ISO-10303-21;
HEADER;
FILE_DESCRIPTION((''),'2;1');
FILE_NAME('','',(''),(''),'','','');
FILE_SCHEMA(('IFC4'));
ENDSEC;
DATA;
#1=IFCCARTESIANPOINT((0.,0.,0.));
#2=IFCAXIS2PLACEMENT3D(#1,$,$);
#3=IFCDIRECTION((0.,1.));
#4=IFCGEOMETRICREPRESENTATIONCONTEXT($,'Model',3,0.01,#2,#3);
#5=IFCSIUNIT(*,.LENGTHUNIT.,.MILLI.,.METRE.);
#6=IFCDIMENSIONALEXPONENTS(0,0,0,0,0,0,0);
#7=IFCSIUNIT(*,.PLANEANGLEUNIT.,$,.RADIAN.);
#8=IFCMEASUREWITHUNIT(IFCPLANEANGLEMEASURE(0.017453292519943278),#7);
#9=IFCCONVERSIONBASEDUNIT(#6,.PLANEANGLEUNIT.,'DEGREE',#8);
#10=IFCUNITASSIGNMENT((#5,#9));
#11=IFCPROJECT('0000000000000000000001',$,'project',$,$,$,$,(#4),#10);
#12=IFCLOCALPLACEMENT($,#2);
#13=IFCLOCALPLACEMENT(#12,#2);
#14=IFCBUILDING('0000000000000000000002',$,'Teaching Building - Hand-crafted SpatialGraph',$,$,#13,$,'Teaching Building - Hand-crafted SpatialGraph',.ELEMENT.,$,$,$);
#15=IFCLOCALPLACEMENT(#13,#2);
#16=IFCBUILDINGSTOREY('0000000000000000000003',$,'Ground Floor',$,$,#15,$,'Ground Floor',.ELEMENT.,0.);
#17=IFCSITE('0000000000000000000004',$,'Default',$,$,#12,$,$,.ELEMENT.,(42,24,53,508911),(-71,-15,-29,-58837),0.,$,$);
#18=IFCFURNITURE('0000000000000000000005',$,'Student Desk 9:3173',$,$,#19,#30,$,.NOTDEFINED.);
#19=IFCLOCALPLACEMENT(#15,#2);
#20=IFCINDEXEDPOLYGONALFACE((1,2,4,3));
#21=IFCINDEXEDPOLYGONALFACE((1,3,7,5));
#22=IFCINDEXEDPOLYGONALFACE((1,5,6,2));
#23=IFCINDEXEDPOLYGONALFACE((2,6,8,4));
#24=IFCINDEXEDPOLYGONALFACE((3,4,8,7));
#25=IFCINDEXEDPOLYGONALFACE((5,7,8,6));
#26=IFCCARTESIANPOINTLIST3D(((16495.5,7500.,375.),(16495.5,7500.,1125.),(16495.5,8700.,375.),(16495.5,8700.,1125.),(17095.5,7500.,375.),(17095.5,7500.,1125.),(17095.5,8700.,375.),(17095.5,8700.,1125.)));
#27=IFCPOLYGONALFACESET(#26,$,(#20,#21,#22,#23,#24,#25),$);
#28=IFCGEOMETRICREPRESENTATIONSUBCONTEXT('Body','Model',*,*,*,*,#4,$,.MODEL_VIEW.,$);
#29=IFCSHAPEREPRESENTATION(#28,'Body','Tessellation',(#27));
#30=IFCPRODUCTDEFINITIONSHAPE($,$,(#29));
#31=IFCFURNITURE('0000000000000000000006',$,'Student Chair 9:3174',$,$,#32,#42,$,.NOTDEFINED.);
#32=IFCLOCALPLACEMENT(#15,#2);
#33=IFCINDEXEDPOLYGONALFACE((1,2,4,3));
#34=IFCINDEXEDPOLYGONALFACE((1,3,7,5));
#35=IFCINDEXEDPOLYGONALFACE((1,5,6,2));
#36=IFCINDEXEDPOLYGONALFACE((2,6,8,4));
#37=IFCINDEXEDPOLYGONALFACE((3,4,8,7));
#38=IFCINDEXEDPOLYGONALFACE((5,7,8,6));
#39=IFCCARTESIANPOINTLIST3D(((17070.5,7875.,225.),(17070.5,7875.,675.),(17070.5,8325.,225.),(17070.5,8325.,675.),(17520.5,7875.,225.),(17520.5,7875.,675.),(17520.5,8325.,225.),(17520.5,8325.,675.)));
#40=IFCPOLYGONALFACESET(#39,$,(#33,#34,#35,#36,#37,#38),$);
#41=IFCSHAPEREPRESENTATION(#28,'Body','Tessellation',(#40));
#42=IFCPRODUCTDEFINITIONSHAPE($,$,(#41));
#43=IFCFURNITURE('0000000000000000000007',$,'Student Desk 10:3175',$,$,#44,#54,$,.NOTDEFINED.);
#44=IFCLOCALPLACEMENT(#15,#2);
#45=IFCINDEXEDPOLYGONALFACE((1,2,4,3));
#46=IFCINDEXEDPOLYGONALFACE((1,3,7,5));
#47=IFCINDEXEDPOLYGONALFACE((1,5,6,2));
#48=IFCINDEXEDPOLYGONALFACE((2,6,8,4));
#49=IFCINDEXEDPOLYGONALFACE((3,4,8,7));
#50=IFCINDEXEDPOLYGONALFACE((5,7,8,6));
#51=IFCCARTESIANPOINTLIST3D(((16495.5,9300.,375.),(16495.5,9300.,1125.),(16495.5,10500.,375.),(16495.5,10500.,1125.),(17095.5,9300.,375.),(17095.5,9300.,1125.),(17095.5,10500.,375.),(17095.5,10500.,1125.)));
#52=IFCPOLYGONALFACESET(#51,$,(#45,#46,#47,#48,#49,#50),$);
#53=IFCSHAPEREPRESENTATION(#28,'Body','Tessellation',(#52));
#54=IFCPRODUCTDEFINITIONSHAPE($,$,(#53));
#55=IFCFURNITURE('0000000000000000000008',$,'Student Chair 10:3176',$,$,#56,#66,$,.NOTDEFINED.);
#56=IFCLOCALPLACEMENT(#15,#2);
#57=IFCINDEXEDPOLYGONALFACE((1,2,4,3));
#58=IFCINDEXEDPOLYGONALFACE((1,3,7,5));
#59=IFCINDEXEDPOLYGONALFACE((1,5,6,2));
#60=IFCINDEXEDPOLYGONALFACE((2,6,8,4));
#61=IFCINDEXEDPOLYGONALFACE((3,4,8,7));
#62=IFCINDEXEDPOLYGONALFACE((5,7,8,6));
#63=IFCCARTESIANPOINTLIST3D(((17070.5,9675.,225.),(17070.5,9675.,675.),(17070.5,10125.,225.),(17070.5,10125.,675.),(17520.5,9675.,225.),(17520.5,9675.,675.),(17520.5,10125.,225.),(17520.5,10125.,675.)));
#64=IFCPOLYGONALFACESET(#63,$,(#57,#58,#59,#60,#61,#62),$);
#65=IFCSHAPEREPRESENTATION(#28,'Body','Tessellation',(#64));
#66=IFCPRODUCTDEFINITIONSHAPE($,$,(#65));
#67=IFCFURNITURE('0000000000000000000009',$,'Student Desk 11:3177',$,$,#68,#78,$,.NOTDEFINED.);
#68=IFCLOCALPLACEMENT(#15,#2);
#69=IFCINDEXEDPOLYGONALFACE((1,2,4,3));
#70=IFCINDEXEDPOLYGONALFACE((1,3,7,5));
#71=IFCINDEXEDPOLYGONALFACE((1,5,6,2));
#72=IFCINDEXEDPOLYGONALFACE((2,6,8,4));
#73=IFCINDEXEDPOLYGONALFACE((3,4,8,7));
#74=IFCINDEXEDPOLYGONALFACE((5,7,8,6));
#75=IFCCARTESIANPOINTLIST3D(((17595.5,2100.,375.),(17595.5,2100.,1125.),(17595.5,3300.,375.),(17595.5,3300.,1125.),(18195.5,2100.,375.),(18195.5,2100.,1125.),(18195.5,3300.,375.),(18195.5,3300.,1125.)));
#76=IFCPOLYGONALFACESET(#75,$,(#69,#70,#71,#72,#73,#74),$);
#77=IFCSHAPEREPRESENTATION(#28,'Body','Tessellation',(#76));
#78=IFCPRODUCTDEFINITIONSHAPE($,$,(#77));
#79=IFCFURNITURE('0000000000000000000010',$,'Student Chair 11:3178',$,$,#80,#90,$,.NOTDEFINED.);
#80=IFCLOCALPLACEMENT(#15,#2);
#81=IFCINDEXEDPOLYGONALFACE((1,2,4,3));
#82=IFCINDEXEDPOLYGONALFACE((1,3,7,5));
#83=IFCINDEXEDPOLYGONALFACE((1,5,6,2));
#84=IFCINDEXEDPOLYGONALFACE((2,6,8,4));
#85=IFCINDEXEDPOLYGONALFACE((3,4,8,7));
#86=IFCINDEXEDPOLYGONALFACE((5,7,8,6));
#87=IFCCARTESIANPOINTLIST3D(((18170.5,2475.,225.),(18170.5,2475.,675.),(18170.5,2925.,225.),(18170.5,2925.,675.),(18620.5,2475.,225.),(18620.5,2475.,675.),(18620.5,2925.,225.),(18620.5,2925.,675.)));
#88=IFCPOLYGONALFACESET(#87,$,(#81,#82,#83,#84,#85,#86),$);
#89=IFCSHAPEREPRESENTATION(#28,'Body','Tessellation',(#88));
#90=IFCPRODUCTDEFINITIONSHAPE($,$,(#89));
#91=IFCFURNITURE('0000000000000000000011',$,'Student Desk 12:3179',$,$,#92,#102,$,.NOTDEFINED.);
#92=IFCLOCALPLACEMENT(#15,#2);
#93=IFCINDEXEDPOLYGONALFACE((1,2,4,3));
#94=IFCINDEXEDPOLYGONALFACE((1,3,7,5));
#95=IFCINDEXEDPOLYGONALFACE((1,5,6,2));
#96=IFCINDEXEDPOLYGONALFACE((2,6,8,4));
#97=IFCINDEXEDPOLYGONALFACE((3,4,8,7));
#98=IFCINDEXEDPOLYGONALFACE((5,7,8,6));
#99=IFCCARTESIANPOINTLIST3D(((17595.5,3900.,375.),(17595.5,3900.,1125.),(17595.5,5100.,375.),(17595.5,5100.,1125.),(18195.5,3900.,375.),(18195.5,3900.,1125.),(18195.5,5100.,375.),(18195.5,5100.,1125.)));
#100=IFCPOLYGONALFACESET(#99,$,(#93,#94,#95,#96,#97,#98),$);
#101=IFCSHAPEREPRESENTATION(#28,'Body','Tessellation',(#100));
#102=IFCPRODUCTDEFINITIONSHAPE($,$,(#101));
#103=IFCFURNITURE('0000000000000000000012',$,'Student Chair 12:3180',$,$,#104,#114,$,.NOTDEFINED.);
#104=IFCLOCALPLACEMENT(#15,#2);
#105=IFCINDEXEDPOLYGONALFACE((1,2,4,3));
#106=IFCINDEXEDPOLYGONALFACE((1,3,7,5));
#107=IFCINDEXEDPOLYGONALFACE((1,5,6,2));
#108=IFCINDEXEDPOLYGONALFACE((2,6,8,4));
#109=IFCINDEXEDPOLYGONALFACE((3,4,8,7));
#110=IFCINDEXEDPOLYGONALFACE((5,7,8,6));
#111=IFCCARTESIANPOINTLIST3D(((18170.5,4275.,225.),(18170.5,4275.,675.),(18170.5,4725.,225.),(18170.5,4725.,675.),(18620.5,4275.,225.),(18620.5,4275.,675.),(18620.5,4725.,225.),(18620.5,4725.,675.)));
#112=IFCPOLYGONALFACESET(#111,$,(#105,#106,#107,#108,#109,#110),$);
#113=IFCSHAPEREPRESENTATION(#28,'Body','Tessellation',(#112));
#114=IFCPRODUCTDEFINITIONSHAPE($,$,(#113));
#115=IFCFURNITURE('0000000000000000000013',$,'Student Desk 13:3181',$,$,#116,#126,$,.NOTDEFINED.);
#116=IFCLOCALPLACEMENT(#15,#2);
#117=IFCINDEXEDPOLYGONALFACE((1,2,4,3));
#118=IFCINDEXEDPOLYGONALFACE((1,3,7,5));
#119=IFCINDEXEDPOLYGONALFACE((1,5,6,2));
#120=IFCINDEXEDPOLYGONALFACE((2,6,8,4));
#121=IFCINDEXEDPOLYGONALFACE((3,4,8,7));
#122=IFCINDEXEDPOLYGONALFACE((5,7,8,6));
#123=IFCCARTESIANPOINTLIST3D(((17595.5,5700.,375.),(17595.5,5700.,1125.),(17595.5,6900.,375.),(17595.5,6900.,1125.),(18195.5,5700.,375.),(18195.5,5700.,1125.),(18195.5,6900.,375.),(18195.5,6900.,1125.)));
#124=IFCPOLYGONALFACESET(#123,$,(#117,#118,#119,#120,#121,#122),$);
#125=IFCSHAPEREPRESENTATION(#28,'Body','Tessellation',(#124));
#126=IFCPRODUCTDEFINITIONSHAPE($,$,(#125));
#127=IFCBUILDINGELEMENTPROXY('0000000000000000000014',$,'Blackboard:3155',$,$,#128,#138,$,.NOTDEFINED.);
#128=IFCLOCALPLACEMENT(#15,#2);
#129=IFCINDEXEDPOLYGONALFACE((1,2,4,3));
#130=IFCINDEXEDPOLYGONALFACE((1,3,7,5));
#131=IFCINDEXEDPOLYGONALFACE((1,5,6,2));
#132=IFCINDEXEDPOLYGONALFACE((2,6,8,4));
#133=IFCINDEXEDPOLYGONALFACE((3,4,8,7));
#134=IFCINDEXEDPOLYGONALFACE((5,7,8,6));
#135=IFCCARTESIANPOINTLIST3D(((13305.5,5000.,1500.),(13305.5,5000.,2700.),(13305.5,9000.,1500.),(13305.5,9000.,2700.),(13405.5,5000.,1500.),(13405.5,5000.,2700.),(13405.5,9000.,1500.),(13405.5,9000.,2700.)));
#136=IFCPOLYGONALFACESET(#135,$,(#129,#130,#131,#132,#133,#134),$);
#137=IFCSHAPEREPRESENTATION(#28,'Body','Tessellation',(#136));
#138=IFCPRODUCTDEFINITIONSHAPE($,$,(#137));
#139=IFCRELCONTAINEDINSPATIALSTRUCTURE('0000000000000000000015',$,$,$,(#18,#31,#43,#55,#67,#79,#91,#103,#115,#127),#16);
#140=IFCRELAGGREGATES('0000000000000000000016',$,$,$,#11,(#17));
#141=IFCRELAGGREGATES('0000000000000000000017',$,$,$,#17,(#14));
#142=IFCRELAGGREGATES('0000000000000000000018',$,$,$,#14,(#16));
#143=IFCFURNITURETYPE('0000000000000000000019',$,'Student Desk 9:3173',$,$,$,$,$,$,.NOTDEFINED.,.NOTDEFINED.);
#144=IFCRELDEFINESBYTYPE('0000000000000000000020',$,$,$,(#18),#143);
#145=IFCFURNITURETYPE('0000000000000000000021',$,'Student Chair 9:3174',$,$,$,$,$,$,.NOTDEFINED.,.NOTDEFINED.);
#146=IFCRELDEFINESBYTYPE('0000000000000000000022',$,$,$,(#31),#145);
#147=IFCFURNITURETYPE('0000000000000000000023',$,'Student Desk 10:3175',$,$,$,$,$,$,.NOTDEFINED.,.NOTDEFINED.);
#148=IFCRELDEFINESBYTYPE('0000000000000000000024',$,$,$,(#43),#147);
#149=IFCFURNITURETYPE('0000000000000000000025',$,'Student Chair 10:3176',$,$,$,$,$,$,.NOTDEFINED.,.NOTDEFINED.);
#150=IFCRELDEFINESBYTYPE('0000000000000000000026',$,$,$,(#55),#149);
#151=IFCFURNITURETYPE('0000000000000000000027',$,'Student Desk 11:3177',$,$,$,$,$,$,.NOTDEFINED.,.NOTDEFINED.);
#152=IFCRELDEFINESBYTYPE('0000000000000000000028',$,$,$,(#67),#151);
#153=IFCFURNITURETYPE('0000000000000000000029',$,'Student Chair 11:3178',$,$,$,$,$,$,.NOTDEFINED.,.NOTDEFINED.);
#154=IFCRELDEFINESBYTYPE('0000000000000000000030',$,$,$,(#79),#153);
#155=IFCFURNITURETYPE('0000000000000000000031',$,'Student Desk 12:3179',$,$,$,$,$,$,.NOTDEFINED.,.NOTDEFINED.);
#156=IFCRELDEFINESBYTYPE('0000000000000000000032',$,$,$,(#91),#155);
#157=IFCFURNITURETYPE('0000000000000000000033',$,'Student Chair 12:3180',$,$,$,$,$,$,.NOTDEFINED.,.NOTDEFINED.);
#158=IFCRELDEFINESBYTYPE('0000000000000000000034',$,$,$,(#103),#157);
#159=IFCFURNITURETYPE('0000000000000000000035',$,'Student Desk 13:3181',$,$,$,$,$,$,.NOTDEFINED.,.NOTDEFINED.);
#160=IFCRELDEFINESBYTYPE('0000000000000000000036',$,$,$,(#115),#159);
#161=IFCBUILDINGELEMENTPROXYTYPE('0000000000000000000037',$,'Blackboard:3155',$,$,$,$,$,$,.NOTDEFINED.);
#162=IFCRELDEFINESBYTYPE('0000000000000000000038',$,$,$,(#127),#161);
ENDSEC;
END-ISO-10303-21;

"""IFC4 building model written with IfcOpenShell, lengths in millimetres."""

from ifc_helpers import new_model, entity, si_unit, converted_unit, direction, frame, frame_2d, origin, origin_2d_with_axis, place, context, subcontext, project, spatial, rectangle, extrude, type_object, element, save


model = new_model("IFC4")

# Units and contexts
model_context = context("Model", 3, precision=0.01, world=origin(), true_north=direction((0.0, 1.0)))
body_context = subcontext(model_context, "Body", "Model", "MODEL_VIEW")
ifc_project = project(units=[si_unit("LENGTHUNIT", "METRE", prefix="MILLI"), converted_unit("PLANEANGLEUNIT", "DEGREE", entity("IfcPlaneAngleMeasure", 0.017453292519943278), si_unit("PLANEANGLEUNIT", "RADIAN"), dimensions=[0, 0, 0, 0, 0, 0, 0])], contexts=[model_context])

# Site, building, storey
site_placement = place(None, origin())
site = spatial("IfcSite", under=ifc_project, at=site_placement, Name="Default", CompositionType="ELEMENT", RefLatitude=(42, 24, 53, 508911), RefLongitude=(-71, -15, -29, -58837), RefElevation=0.0)
building_placement = place(site_placement, origin())
building = spatial("IfcBuilding", under=site, at=building_placement, Name="Teaching Building - Hand-crafted SpatialGraph", LongName="Teaching Building - Hand-crafted SpatialGraph", CompositionType="ELEMENT")
storey_placement = place(building_placement, origin())
storey = spatial("IfcBuildingStorey", under=building, at=storey_placement, Name="Ground Floor", LongName="Ground Floor", CompositionType="ELEMENT", Elevation=0.0)

# Furniture
furniture_type_1 = type_object("IfcFurnitureType", Name="Student Desk 9:3173", PredefinedType="NOTDEFINED")
furniture_1_placement = place(storey_placement, origin())
element("IfcFurniture", 1, at=furniture_1_placement, inside=storey, type_object=furniture_type_1, Name="Student Desk 9:3173", PredefinedType="NOTDEFINED", context=body_context, shape_type="SweptSolid", body=[
    extrude(rectangle(XDim=1200.0, YDim=600.0, at=origin_2d_with_axis()), frame((16795.5, 8100.0, 375.0), z_axis=(0.0, 0.0, 1.0), x_axis=(0.0, 1.0, 0.0)), (0.0, 0.0, 1.0), 750.0),
])
furniture_type_2 = type_object("IfcFurnitureType", Name="Student Chair 9:3174", PredefinedType="NOTDEFINED")
furniture_2_placement = place(storey_placement, origin())
element("IfcFurniture", 2, at=furniture_2_placement, inside=storey, type_object=furniture_type_2, Name="Student Chair 9:3174", PredefinedType="NOTDEFINED", context=body_context, shape_type="SweptSolid", body=[
    extrude(rectangle(XDim=450.0, YDim=450.0, at=origin_2d_with_axis()), frame((17295.5, 8100.0, 225.0)), (0.0, 0.0, 1.0), 450.0),
])
furniture_type_3 = type_object("IfcFurnitureType", Name="Student Desk 10:3175", PredefinedType="NOTDEFINED")
furniture_3_placement = place(storey_placement, origin())
element("IfcFurniture", 3, at=furniture_3_placement, inside=storey, type_object=furniture_type_3, Name="Student Desk 10:3175", PredefinedType="NOTDEFINED", context=body_context, shape_type="SweptSolid", body=[
    extrude(rectangle(XDim=1200.0, YDim=600.0, at=origin_2d_with_axis()), frame((16795.5, 9900.0, 375.0), z_axis=(0.0, 0.0, 1.0), x_axis=(0.0, 1.0, 0.0)), (0.0, 0.0, 1.0), 750.0),
])
furniture_type_4 = type_object("IfcFurnitureType", Name="Student Chair 10:3176", PredefinedType="NOTDEFINED")
furniture_4_placement = place(storey_placement, origin())
element("IfcFurniture", 4, at=furniture_4_placement, inside=storey, type_object=furniture_type_4, Name="Student Chair 10:3176", PredefinedType="NOTDEFINED", context=body_context, shape_type="SweptSolid", body=[
    extrude(rectangle(XDim=450.0, YDim=450.0, at=frame_2d((0.0, 0.0), x_axis=(1.0, 0.0))), frame((17295.5, 9900.0, 225.0)), (0.0, 0.0, 1.0), 450.0),
])
furniture_type_5 = type_object("IfcFurnitureType", Name="Student Desk 11:3177", PredefinedType="NOTDEFINED")
furniture_5_placement = place(storey_placement, origin())
element("IfcFurniture", 5, at=furniture_5_placement, inside=storey, type_object=furniture_type_5, Name="Student Desk 11:3177", PredefinedType="NOTDEFINED", context=body_context, shape_type="SweptSolid", body=[
    extrude(rectangle(XDim=1200.0, YDim=600.0, at=origin_2d_with_axis()), frame((17895.5, 2700.0, 375.0), z_axis=(0.0, 0.0, 1.0), x_axis=(0.0, 1.0, 0.0)), (0.0, 0.0, 1.0), 750.0),
])
furniture_type_6 = type_object("IfcFurnitureType", Name="Student Chair 11:3178", PredefinedType="NOTDEFINED")
furniture_6_placement = place(storey_placement, origin())
element("IfcFurniture", 6, at=furniture_6_placement, inside=storey, type_object=furniture_type_6, Name="Student Chair 11:3178", PredefinedType="NOTDEFINED", context=body_context, shape_type="SweptSolid", body=[
    extrude(rectangle(XDim=450.0, YDim=450.0, at=origin_2d_with_axis()), frame((18395.5, 2700.0, 225.0)), (0.0, 0.0, 1.0), 450.0),
])
furniture_type_7 = type_object("IfcFurnitureType", Name="Student Desk 12:3179", PredefinedType="NOTDEFINED")
furniture_7_placement = place(storey_placement, origin())
element("IfcFurniture", 7, at=furniture_7_placement, inside=storey, type_object=furniture_type_7, Name="Student Desk 12:3179", PredefinedType="NOTDEFINED", context=body_context, shape_type="SweptSolid", body=[
    extrude(rectangle(XDim=1200.0, YDim=600.0, at=frame_2d((0.0, 0.0), x_axis=(1.0, 0.0))), frame((17895.5, 4500.0, 375.0), z_axis=(0.0, 0.0, 1.0), x_axis=(0.0, 1.0, 0.0)), (0.0, 0.0, 1.0), 750.0),
])
furniture_type_8 = type_object("IfcFurnitureType", Name="Student Chair 12:3180", PredefinedType="NOTDEFINED")
furniture_8_placement = place(storey_placement, origin())
element("IfcFurniture", 8, at=furniture_8_placement, inside=storey, type_object=furniture_type_8, Name="Student Chair 12:3180", PredefinedType="NOTDEFINED", context=body_context, shape_type="SweptSolid", body=[
    extrude(rectangle(XDim=450.0, YDim=450.0, at=origin_2d_with_axis()), frame((18395.5, 4500.0, 225.0)), (0.0, 0.0, 1.0), 450.0),
])
furniture_type_9 = type_object("IfcFurnitureType", Name="Student Desk 13:3181", PredefinedType="NOTDEFINED")
furniture_9_placement = place(storey_placement, origin())
element("IfcFurniture", 9, at=furniture_9_placement, inside=storey, type_object=furniture_type_9, Name="Student Desk 13:3181", PredefinedType="NOTDEFINED", context=body_context, shape_type="SweptSolid", body=[
    extrude(rectangle(XDim=1200.0, YDim=600.0, at=origin_2d_with_axis()), frame((17895.5, 6300.0, 375.0), z_axis=(0.0, 0.0, 1.0), x_axis=(0.0, 1.0, 0.0)), (0.0, 0.0, 1.0), 750.0),
])

# Building element proxy
building_element_proxy_type = type_object("IfcBuildingElementProxyType", Name="Blackboard:3155", PredefinedType="NOTDEFINED")
proxy_placement = place(storey_placement, origin())
element("IfcBuildingElementProxy", 10, at=proxy_placement, inside=storey, type_object=building_element_proxy_type, Name="Blackboard:3155", PredefinedType="NOTDEFINED", context=body_context, shape_type="SweptSolid", body=[
    extrude(rectangle(XDim=100.0, YDim=4000.0, at=origin_2d_with_axis()), frame((13355.5, 7000.0, 1500.0)), (0.0, 0.0, 1.0), 1200.0),
])

save(model, "model.ifc")
